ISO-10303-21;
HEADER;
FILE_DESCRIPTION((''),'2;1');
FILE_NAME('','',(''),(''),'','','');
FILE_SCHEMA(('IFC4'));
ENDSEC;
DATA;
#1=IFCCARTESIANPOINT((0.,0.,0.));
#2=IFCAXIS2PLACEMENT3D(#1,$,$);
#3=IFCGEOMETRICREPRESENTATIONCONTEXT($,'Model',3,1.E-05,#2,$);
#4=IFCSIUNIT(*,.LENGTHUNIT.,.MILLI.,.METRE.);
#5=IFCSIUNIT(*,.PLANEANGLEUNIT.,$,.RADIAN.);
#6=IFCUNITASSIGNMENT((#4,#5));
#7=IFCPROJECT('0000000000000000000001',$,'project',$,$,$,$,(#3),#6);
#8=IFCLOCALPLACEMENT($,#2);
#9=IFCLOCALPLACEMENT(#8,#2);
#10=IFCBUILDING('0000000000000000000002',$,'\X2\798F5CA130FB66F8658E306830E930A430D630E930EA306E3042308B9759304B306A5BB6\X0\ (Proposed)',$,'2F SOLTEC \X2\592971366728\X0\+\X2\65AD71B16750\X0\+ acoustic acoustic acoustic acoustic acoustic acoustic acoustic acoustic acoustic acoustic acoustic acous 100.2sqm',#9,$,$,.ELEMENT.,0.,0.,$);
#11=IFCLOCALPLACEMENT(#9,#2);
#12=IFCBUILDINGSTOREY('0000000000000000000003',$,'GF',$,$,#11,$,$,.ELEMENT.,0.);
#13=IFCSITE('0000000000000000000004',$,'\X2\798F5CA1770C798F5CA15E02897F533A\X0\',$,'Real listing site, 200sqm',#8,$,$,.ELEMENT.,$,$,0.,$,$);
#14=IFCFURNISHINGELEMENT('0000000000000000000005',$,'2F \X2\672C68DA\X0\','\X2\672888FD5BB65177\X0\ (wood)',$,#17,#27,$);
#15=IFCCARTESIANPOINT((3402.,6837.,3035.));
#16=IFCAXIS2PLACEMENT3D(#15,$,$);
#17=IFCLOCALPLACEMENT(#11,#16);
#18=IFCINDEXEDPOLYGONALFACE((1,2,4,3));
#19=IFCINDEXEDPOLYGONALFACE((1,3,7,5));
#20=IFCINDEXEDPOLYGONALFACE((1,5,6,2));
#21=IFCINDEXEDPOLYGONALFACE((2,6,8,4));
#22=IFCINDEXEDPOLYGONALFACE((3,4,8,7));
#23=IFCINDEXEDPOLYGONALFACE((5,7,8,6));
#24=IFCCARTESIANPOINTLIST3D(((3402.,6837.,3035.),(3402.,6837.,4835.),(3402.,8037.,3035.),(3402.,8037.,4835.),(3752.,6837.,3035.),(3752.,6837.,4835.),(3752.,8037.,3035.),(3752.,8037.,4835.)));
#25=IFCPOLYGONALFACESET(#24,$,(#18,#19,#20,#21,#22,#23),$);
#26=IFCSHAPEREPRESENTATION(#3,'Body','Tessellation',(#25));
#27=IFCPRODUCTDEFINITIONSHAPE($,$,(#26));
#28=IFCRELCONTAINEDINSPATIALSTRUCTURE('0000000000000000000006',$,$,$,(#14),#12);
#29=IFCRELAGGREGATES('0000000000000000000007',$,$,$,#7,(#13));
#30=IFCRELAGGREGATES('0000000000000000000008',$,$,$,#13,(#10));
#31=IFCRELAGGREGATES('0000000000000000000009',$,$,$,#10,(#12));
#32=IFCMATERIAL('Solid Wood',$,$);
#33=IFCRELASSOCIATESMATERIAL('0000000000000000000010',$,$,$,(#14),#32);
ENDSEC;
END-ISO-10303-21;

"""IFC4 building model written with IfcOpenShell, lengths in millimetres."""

from ifc_helpers import new_model, si_unit, frame, frame_2d, origin, place, context, project, spatial, rectangle, extrude, material, element, save


model = new_model("IFC4")

# Units and contexts
model_context = context("Model", 3, precision=1e-05, world=origin())
ifc_project = project(units=[si_unit("LENGTHUNIT", "METRE", prefix="MILLI"), si_unit("PLANEANGLEUNIT", "RADIAN")], contexts=[model_context])

# Site, building, storey
site_placement = place(None, origin())
site = spatial("IfcSite", under=ifc_project, at=site_placement, Name="福岡県福岡市西区", ObjectType="Real listing site, 200sqm", CompositionType="ELEMENT", RefElevation=0.0)
building_placement = place(site_placement, origin())
building = spatial("IfcBuilding", under=site, at=building_placement, Name="福岡・書斎とライブラリのある静かな家 (Proposed)", ObjectType="2F SOLTEC 天然木+断熱材+ acoustic acoustic acoustic acoustic acoustic acoustic acoustic acoustic acoustic acoustic acoustic acous 100.2sqm", CompositionType="ELEMENT", ElevationOfRefHeight=0.0, ElevationOfTerrain=0.0)
storey_placement = place(building_placement, origin())
storey = spatial("IfcBuildingStorey", under=building, at=storey_placement, Name="GF", CompositionType="ELEMENT", Elevation=0.0)

# Shared definitions
ifc_material_1 = material(Name="Solid Wood")

# Furnishing element
furnishing_placement = place(storey_placement, frame((3402.0, 6837.0, 3035.0)))
element("IfcFurnishingElement", 1, at=furnishing_placement, inside=storey, material=ifc_material_1, Name="2F 本棚", Description="木製家具 (wood)", context=model_context, shape_type="SweptSolid", body=[
    extrude(rectangle(XDim=350.0, YDim=1200.0, at=frame_2d((175.0, 600.0))), frame((3402.0, 6837.0, 3035.0)), (0.0, 0.0, 1.0), 1800.0),
])

save(model, "model.ifc")
